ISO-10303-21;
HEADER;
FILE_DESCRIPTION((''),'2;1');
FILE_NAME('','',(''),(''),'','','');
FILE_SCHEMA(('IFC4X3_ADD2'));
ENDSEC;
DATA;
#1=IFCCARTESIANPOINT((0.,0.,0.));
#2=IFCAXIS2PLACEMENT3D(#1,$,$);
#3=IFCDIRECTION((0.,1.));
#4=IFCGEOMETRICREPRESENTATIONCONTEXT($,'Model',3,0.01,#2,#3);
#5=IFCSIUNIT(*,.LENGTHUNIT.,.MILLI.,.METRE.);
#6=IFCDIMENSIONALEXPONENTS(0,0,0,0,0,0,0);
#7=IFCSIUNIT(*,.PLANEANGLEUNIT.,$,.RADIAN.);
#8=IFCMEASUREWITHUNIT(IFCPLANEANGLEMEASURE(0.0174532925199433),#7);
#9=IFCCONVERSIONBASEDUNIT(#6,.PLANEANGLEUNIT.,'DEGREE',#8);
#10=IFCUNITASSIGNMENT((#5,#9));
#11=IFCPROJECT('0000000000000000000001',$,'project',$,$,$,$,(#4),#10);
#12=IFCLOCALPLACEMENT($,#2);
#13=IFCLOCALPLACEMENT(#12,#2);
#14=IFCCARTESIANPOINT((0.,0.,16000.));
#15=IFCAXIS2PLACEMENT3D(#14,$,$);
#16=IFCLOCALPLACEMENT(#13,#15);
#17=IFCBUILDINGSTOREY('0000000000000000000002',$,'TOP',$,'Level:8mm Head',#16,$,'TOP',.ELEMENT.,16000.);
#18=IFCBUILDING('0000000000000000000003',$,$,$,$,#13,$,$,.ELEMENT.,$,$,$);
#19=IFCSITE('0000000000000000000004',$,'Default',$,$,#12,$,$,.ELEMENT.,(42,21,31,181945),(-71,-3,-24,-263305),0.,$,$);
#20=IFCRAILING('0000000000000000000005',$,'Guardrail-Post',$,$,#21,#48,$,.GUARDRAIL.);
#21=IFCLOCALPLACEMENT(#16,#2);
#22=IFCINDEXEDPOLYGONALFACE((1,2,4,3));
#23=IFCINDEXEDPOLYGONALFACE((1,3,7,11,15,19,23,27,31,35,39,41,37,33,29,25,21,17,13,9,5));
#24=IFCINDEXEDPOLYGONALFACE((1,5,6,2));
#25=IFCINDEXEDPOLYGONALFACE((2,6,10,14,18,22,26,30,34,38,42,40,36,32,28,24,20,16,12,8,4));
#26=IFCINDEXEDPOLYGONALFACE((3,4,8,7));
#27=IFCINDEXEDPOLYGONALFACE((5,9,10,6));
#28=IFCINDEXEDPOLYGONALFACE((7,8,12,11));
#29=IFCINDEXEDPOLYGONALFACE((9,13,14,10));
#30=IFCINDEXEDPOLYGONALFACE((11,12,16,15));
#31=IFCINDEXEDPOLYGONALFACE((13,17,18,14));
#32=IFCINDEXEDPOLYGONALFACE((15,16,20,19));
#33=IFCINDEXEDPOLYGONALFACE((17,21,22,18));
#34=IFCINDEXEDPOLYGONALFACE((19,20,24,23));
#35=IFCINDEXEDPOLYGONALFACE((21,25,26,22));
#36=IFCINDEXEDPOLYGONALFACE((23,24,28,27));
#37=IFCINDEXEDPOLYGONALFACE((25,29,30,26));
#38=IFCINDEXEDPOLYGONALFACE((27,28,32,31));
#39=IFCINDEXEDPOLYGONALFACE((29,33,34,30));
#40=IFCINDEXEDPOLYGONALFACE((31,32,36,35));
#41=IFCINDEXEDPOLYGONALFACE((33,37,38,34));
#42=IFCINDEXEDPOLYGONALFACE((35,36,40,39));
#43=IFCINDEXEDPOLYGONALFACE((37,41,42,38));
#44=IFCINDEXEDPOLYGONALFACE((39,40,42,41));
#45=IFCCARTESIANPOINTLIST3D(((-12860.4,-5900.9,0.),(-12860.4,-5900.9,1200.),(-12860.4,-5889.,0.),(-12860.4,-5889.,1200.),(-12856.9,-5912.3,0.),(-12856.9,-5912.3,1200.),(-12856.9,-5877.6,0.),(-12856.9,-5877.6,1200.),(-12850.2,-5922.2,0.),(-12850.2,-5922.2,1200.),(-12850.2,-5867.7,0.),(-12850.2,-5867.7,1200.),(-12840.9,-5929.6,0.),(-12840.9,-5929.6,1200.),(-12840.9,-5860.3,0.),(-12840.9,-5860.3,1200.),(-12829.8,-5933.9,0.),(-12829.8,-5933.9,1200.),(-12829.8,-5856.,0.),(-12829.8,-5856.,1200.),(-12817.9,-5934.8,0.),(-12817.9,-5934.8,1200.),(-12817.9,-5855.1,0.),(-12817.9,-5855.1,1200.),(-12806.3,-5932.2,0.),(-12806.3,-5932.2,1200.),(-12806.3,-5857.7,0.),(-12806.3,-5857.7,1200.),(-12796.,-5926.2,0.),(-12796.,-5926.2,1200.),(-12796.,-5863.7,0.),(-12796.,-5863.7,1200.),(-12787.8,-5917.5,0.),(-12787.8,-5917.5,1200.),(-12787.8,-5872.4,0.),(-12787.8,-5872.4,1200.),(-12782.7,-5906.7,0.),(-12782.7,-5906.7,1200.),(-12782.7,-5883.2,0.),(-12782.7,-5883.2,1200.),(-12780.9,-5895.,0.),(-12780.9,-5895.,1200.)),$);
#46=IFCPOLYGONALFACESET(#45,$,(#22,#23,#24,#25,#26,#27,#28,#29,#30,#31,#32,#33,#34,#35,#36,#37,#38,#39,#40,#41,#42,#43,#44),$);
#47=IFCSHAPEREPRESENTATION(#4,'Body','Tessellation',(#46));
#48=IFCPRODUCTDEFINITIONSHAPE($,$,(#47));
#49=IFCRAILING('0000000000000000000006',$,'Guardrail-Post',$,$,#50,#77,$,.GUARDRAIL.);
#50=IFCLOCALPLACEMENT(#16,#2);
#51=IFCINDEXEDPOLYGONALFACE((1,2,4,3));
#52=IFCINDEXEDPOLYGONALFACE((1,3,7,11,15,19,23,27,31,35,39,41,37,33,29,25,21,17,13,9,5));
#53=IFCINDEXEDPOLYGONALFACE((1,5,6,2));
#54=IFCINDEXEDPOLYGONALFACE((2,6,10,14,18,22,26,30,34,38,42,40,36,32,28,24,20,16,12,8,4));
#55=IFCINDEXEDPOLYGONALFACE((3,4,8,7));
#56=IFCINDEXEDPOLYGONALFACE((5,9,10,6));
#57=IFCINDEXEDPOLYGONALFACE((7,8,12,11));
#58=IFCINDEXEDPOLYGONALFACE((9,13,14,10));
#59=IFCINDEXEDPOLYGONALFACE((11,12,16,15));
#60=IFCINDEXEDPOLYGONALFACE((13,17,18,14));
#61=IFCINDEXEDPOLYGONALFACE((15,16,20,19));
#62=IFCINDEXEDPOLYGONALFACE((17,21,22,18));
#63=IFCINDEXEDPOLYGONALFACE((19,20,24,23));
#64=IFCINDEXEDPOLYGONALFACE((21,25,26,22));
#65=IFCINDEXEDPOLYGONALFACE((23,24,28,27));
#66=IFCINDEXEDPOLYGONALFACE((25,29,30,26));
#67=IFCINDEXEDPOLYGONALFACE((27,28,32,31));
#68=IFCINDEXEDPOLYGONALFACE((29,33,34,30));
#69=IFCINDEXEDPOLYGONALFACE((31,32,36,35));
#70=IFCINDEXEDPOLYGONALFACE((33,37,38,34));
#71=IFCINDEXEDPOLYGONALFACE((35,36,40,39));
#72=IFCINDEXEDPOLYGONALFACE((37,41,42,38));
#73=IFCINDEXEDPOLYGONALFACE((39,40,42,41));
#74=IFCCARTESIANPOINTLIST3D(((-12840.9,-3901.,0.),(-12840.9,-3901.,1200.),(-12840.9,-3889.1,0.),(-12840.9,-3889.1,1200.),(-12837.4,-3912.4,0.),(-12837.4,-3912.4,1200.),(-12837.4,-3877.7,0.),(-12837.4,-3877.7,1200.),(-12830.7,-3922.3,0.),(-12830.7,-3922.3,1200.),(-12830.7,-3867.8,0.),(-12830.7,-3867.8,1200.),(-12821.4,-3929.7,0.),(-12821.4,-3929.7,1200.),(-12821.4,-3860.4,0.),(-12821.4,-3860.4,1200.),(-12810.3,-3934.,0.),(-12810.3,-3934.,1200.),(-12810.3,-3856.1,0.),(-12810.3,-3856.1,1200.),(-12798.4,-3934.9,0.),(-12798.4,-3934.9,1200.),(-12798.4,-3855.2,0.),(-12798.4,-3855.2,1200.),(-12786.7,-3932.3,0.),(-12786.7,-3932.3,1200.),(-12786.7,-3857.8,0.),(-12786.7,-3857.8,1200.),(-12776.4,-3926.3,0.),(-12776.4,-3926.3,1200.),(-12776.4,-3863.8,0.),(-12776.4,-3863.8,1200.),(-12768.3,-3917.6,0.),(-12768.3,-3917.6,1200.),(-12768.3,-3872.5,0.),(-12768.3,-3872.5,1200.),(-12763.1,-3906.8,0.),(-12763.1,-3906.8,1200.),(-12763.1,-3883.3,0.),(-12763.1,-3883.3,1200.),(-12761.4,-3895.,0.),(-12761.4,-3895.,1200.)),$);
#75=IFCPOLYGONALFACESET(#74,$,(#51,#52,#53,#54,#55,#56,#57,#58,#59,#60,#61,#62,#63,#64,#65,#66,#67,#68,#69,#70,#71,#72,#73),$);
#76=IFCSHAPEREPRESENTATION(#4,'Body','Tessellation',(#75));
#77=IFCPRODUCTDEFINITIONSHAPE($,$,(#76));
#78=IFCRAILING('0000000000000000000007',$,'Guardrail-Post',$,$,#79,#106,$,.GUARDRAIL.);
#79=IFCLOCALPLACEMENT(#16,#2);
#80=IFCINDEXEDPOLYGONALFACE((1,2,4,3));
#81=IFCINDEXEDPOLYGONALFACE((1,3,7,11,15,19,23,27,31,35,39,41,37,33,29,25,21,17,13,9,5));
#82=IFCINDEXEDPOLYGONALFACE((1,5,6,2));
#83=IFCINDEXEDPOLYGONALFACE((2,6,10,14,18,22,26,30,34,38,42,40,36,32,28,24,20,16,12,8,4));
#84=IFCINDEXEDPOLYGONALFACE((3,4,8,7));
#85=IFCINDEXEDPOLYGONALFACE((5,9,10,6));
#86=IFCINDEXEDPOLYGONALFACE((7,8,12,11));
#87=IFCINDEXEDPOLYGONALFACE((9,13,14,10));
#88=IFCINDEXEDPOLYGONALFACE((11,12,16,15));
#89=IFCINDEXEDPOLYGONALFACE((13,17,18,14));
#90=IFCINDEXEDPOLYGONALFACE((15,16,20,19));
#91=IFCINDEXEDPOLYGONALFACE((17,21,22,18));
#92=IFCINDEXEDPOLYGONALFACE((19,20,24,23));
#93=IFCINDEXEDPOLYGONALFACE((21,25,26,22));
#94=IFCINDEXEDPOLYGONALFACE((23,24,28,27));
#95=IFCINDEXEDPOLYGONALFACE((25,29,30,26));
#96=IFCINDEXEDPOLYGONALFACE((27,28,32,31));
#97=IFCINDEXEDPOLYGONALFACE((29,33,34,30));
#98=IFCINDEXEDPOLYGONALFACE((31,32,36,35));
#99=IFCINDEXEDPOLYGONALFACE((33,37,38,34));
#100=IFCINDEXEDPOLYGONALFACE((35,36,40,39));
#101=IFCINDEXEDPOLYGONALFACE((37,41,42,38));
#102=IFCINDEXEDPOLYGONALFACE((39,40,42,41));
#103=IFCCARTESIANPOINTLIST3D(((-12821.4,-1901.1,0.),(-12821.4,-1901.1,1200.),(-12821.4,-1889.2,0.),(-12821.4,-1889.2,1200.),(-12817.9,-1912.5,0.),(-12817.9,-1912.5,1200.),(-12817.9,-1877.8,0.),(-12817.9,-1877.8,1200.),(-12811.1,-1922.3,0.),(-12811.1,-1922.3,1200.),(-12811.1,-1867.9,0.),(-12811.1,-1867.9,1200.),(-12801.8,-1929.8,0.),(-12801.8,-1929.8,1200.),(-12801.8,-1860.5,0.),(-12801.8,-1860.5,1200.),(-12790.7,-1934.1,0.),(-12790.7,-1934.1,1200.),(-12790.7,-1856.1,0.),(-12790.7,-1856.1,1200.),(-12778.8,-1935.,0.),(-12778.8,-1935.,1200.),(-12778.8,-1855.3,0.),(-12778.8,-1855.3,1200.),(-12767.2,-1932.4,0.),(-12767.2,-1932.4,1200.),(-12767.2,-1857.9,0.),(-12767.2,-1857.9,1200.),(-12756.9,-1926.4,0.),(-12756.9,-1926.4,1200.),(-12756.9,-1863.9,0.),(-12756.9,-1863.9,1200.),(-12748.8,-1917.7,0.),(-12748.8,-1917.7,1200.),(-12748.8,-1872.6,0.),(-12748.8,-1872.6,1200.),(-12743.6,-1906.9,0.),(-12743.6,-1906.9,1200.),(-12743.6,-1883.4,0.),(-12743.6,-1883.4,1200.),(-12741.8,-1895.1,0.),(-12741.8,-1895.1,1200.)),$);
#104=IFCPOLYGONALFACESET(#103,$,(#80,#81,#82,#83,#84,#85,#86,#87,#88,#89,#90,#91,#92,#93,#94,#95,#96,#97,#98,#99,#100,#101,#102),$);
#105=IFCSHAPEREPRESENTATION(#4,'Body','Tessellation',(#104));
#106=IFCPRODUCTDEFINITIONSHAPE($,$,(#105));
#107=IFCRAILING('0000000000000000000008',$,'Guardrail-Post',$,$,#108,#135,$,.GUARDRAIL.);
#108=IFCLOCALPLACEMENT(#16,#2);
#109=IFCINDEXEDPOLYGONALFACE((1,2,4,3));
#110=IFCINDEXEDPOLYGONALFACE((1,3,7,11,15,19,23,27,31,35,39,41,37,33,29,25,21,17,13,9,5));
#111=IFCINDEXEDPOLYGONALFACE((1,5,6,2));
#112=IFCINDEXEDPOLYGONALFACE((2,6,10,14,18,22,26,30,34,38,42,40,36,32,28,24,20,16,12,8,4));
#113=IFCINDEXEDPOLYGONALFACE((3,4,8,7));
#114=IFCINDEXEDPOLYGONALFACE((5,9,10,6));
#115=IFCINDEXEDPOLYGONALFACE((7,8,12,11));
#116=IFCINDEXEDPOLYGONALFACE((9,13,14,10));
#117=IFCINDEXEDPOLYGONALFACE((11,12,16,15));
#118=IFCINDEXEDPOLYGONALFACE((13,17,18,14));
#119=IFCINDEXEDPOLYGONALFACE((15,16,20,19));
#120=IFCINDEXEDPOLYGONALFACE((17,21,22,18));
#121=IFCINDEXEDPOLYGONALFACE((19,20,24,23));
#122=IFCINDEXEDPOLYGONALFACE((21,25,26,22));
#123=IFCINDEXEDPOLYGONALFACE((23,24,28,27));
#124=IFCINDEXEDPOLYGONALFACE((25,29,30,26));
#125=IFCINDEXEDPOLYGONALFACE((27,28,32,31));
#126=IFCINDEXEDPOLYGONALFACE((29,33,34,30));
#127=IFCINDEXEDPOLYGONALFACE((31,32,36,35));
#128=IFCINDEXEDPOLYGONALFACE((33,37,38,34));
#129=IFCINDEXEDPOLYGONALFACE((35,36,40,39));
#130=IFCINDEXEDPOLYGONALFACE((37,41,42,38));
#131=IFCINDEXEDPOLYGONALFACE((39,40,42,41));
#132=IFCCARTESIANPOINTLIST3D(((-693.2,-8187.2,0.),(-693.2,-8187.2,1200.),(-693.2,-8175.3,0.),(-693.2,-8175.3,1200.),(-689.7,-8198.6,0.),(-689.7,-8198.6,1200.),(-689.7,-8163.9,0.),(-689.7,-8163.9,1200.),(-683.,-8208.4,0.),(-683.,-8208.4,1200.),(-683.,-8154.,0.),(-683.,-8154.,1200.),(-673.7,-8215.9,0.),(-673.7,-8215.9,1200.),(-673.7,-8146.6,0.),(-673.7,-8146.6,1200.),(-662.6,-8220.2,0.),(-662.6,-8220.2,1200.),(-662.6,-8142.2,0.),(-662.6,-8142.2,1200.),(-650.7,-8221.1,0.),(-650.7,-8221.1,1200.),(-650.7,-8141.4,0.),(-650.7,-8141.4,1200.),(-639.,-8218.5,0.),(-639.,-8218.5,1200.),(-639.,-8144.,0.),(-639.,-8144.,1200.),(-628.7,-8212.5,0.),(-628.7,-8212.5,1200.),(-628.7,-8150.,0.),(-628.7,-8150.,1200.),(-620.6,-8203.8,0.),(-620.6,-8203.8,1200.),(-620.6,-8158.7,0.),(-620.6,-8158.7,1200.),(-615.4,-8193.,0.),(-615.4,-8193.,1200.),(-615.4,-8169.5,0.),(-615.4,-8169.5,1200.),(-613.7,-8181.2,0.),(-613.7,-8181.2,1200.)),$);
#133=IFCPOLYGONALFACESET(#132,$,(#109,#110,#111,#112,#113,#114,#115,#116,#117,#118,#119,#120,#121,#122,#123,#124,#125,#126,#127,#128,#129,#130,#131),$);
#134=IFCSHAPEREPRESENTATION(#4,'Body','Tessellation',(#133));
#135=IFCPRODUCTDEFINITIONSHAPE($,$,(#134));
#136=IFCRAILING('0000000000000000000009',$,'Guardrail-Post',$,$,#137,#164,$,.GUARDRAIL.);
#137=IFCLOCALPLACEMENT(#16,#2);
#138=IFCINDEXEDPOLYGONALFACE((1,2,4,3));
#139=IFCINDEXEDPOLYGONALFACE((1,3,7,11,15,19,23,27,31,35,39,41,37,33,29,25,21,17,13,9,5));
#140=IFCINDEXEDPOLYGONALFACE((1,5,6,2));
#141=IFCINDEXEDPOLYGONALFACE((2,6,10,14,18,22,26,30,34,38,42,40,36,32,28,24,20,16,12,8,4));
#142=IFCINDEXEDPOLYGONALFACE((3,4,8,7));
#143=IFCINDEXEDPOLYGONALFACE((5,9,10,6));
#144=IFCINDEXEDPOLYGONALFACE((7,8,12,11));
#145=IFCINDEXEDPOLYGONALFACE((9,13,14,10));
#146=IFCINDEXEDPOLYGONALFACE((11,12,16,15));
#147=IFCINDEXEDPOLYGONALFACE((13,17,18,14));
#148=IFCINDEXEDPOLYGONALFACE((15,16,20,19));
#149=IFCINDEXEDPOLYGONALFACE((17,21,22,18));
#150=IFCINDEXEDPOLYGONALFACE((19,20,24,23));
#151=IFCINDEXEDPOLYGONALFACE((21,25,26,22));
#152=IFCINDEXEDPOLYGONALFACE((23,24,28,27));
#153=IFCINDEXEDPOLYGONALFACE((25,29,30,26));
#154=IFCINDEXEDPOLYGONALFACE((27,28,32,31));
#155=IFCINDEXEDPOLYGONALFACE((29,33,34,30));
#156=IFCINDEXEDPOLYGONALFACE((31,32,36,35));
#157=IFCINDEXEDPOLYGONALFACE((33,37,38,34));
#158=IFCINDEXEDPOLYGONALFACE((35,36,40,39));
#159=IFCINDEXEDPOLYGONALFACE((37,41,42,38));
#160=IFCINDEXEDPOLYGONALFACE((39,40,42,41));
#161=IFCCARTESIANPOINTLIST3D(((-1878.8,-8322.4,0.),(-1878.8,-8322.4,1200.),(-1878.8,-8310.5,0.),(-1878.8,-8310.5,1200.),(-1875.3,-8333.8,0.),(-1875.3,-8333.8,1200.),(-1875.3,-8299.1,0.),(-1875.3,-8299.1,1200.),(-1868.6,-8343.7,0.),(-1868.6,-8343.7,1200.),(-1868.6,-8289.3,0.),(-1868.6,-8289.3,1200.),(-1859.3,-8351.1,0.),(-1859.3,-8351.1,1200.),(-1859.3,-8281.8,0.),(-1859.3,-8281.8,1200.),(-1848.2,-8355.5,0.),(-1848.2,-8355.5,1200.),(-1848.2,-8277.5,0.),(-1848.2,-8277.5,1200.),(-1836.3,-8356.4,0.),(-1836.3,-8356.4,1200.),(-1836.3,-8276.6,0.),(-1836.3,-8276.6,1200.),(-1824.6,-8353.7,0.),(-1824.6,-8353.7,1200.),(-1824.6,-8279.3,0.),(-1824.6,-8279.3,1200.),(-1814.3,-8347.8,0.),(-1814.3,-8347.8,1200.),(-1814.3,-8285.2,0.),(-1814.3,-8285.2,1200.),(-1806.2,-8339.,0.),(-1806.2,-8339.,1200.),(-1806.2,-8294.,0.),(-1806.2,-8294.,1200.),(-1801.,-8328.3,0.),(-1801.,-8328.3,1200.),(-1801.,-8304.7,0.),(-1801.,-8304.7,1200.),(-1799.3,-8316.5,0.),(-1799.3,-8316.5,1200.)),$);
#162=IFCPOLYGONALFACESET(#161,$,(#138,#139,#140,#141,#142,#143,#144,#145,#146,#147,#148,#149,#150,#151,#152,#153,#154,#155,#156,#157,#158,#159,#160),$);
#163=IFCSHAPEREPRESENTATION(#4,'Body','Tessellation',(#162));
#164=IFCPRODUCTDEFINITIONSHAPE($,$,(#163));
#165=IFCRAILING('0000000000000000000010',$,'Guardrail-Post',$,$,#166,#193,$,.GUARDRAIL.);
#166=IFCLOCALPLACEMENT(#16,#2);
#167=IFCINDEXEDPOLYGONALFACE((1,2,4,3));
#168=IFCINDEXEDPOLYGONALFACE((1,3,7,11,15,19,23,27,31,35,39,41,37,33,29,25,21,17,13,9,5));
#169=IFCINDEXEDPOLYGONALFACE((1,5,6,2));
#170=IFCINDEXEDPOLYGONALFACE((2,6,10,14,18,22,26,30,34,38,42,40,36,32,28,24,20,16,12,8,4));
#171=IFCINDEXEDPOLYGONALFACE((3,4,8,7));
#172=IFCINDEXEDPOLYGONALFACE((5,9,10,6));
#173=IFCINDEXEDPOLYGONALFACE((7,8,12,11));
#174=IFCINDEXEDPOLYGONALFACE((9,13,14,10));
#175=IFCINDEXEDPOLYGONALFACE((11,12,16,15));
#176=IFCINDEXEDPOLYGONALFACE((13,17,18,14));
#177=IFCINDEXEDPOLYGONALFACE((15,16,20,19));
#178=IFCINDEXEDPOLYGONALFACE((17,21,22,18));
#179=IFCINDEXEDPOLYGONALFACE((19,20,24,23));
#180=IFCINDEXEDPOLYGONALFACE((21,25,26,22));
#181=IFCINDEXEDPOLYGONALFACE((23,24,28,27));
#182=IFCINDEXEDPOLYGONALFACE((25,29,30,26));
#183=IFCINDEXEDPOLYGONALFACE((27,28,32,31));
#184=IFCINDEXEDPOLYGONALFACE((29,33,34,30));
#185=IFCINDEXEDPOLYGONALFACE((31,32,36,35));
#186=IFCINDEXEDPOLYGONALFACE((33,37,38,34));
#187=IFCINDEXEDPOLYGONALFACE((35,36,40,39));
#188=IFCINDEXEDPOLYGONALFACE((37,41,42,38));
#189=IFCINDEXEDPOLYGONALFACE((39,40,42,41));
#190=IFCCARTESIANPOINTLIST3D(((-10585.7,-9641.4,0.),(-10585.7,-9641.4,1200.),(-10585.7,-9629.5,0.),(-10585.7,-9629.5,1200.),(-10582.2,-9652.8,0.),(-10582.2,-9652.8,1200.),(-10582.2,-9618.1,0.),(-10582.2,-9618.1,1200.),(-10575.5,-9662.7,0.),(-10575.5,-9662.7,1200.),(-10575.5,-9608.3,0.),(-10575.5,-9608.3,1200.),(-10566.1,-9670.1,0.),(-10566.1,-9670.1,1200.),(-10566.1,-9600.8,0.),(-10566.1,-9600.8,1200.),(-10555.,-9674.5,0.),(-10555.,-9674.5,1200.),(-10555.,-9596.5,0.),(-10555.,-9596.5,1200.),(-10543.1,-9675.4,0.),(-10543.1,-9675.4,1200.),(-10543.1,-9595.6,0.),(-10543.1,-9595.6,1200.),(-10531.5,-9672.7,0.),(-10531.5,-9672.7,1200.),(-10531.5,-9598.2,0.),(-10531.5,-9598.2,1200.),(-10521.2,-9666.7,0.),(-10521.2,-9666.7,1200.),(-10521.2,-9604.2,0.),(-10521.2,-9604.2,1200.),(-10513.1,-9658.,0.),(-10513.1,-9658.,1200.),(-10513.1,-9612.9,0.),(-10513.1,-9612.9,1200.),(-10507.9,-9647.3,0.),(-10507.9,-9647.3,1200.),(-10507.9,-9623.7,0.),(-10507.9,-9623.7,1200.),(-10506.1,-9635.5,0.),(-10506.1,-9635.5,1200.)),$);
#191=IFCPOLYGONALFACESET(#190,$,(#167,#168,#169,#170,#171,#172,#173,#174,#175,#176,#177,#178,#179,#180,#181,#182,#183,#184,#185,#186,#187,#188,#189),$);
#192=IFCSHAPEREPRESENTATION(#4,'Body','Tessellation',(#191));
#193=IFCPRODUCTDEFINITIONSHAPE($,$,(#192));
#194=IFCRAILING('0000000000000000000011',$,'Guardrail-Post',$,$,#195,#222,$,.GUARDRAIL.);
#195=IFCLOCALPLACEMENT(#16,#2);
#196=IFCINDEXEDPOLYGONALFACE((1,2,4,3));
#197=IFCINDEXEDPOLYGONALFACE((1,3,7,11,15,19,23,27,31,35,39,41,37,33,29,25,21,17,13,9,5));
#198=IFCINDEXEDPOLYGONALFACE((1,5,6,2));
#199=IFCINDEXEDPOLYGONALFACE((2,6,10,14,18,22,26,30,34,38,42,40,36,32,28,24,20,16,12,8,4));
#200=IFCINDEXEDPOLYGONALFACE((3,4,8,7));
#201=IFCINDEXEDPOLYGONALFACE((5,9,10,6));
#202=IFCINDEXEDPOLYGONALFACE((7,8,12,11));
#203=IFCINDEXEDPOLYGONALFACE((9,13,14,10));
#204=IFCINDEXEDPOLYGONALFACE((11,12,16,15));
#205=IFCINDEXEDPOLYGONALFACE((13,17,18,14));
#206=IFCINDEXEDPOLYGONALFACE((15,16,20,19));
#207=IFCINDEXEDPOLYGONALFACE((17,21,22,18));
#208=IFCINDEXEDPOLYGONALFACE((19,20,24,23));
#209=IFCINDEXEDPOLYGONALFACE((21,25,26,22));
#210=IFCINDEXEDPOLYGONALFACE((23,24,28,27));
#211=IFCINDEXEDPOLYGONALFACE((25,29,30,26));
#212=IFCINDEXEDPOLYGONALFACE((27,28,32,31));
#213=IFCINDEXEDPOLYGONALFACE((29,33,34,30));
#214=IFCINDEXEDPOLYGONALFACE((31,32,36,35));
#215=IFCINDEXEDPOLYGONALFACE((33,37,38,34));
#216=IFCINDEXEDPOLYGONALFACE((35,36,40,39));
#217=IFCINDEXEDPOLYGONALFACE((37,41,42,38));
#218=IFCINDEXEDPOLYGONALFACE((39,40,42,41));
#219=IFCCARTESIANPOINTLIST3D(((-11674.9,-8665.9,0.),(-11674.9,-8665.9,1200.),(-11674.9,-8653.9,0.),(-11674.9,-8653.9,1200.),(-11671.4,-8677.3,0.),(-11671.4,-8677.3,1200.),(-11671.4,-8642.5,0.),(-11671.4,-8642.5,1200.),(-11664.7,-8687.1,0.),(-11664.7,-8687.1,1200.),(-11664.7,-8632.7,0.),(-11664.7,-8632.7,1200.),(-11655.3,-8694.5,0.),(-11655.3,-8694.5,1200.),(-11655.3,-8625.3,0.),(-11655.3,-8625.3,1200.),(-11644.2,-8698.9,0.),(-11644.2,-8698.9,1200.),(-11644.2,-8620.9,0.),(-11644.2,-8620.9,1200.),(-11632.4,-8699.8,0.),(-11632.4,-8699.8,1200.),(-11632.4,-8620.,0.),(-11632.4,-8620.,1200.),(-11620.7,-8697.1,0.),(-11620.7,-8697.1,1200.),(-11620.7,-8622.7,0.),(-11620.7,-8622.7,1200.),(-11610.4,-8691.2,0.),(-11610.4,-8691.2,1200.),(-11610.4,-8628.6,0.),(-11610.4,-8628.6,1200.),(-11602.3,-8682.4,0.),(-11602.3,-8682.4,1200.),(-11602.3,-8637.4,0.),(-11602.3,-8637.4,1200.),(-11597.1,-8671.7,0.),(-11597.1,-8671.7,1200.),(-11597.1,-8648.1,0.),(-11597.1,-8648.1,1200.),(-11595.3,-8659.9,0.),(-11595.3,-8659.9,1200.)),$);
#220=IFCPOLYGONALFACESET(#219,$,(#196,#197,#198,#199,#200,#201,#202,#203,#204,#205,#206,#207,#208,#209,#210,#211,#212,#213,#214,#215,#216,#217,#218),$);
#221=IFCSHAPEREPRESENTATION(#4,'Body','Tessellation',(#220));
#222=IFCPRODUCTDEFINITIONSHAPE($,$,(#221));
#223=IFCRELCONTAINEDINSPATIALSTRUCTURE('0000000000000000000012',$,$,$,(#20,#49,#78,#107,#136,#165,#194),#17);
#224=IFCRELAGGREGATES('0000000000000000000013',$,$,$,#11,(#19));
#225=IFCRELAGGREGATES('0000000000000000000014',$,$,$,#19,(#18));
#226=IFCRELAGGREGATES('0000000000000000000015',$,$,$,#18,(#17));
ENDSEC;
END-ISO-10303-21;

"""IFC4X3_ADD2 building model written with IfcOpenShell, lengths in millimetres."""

from ifc_helpers import new_model, entity, si_unit, converted_unit, direction, frame, origin, origin_with_axes, origin_2d, place, context, project, spatial, circle, extrude, element, save


model = new_model("IFC4X3_ADD2")

# Units and contexts
model_context = context("Model", 3, precision=0.01, world=origin(), true_north=direction((0.0, 1.0)))
ifc_project = project(units=[si_unit("LENGTHUNIT", "METRE", prefix="MILLI"), converted_unit("PLANEANGLEUNIT", "DEGREE", entity("IfcPlaneAngleMeasure", 0.0174532925199433), si_unit("PLANEANGLEUNIT", "RADIAN"), dimensions=[0, 0, 0, 0, 0, 0, 0])], contexts=[model_context])

# Site, building, storey
site_placement = place(None, origin())
site = spatial("IfcSite", under=ifc_project, at=site_placement, Name="Default", CompositionType="ELEMENT", RefLatitude=(42, 21, 31, 181945), RefLongitude=(-71, -3, -24, -263305), RefElevation=0.0)
building_placement = place(site_placement, origin())
building = spatial("IfcBuilding", under=site, at=building_placement, CompositionType="ELEMENT")
storey_placement = place(building_placement, frame((0.0, 0.0, 16000.0)))
storey = spatial("IfcBuildingStorey", under=building, at=storey_placement, Name="TOP", ObjectType="Level:8mm Head", LongName="TOP", CompositionType="ELEMENT", Elevation=16000.0)

# Railings
for number, where, z_axis, x_axis, name in (
    (1, (-12820.9, -5895.0, 16000.0), (0.0, 0.0, 1.0), (1.0, 0.0, 0.0), "Guardrail-Post"),
    (2, (-12801.4, -3895.0, 16000.0), (0.0, 0.0, 1.0), (1.0, 0.0, 0.0), "Guardrail-Post"),
    (3, (-12781.8, -1895.1, 16000.0), (0.0, 0.0, 1.0), (1.0, 0.0, 0.0), "Guardrail-Post"),
    (4, (-653.7, -8181.2, 16000.0), (0.0, 0.0, 1.0), (1.0, 0.0, 0.0), "Guardrail-Post"),
    (5, (-1839.3, -8316.5, 16000.0), (0.0, 0.0, 1.0), (1.0, 0.0, 0.0), "Guardrail-Post"),
    (6, (-10546.1, -9635.5, 16000.0), (0.0, 0.0, 1.0), (1.0, 0.0, 0.0), "Guardrail-Post"),
    (7, (-11635.3, -8659.9, 16000.0), (0.0, 0.0, 1.0), (1.0, 0.0, 0.0), "Guardrail-Post"),
):
    element("IfcRailing", number, at=place(None, frame(where, z_axis=z_axis, x_axis=x_axis)), inside=storey, Name=name, PredefinedType="GUARDRAIL", context=model_context, shape_type="SweptSolid", body=[
        extrude(circle(Radius=40.0, at=origin_2d()), origin_with_axes(), (0.0, 0.0, 1.0), 1200.0),
    ])

save(model, "model.ifc")
